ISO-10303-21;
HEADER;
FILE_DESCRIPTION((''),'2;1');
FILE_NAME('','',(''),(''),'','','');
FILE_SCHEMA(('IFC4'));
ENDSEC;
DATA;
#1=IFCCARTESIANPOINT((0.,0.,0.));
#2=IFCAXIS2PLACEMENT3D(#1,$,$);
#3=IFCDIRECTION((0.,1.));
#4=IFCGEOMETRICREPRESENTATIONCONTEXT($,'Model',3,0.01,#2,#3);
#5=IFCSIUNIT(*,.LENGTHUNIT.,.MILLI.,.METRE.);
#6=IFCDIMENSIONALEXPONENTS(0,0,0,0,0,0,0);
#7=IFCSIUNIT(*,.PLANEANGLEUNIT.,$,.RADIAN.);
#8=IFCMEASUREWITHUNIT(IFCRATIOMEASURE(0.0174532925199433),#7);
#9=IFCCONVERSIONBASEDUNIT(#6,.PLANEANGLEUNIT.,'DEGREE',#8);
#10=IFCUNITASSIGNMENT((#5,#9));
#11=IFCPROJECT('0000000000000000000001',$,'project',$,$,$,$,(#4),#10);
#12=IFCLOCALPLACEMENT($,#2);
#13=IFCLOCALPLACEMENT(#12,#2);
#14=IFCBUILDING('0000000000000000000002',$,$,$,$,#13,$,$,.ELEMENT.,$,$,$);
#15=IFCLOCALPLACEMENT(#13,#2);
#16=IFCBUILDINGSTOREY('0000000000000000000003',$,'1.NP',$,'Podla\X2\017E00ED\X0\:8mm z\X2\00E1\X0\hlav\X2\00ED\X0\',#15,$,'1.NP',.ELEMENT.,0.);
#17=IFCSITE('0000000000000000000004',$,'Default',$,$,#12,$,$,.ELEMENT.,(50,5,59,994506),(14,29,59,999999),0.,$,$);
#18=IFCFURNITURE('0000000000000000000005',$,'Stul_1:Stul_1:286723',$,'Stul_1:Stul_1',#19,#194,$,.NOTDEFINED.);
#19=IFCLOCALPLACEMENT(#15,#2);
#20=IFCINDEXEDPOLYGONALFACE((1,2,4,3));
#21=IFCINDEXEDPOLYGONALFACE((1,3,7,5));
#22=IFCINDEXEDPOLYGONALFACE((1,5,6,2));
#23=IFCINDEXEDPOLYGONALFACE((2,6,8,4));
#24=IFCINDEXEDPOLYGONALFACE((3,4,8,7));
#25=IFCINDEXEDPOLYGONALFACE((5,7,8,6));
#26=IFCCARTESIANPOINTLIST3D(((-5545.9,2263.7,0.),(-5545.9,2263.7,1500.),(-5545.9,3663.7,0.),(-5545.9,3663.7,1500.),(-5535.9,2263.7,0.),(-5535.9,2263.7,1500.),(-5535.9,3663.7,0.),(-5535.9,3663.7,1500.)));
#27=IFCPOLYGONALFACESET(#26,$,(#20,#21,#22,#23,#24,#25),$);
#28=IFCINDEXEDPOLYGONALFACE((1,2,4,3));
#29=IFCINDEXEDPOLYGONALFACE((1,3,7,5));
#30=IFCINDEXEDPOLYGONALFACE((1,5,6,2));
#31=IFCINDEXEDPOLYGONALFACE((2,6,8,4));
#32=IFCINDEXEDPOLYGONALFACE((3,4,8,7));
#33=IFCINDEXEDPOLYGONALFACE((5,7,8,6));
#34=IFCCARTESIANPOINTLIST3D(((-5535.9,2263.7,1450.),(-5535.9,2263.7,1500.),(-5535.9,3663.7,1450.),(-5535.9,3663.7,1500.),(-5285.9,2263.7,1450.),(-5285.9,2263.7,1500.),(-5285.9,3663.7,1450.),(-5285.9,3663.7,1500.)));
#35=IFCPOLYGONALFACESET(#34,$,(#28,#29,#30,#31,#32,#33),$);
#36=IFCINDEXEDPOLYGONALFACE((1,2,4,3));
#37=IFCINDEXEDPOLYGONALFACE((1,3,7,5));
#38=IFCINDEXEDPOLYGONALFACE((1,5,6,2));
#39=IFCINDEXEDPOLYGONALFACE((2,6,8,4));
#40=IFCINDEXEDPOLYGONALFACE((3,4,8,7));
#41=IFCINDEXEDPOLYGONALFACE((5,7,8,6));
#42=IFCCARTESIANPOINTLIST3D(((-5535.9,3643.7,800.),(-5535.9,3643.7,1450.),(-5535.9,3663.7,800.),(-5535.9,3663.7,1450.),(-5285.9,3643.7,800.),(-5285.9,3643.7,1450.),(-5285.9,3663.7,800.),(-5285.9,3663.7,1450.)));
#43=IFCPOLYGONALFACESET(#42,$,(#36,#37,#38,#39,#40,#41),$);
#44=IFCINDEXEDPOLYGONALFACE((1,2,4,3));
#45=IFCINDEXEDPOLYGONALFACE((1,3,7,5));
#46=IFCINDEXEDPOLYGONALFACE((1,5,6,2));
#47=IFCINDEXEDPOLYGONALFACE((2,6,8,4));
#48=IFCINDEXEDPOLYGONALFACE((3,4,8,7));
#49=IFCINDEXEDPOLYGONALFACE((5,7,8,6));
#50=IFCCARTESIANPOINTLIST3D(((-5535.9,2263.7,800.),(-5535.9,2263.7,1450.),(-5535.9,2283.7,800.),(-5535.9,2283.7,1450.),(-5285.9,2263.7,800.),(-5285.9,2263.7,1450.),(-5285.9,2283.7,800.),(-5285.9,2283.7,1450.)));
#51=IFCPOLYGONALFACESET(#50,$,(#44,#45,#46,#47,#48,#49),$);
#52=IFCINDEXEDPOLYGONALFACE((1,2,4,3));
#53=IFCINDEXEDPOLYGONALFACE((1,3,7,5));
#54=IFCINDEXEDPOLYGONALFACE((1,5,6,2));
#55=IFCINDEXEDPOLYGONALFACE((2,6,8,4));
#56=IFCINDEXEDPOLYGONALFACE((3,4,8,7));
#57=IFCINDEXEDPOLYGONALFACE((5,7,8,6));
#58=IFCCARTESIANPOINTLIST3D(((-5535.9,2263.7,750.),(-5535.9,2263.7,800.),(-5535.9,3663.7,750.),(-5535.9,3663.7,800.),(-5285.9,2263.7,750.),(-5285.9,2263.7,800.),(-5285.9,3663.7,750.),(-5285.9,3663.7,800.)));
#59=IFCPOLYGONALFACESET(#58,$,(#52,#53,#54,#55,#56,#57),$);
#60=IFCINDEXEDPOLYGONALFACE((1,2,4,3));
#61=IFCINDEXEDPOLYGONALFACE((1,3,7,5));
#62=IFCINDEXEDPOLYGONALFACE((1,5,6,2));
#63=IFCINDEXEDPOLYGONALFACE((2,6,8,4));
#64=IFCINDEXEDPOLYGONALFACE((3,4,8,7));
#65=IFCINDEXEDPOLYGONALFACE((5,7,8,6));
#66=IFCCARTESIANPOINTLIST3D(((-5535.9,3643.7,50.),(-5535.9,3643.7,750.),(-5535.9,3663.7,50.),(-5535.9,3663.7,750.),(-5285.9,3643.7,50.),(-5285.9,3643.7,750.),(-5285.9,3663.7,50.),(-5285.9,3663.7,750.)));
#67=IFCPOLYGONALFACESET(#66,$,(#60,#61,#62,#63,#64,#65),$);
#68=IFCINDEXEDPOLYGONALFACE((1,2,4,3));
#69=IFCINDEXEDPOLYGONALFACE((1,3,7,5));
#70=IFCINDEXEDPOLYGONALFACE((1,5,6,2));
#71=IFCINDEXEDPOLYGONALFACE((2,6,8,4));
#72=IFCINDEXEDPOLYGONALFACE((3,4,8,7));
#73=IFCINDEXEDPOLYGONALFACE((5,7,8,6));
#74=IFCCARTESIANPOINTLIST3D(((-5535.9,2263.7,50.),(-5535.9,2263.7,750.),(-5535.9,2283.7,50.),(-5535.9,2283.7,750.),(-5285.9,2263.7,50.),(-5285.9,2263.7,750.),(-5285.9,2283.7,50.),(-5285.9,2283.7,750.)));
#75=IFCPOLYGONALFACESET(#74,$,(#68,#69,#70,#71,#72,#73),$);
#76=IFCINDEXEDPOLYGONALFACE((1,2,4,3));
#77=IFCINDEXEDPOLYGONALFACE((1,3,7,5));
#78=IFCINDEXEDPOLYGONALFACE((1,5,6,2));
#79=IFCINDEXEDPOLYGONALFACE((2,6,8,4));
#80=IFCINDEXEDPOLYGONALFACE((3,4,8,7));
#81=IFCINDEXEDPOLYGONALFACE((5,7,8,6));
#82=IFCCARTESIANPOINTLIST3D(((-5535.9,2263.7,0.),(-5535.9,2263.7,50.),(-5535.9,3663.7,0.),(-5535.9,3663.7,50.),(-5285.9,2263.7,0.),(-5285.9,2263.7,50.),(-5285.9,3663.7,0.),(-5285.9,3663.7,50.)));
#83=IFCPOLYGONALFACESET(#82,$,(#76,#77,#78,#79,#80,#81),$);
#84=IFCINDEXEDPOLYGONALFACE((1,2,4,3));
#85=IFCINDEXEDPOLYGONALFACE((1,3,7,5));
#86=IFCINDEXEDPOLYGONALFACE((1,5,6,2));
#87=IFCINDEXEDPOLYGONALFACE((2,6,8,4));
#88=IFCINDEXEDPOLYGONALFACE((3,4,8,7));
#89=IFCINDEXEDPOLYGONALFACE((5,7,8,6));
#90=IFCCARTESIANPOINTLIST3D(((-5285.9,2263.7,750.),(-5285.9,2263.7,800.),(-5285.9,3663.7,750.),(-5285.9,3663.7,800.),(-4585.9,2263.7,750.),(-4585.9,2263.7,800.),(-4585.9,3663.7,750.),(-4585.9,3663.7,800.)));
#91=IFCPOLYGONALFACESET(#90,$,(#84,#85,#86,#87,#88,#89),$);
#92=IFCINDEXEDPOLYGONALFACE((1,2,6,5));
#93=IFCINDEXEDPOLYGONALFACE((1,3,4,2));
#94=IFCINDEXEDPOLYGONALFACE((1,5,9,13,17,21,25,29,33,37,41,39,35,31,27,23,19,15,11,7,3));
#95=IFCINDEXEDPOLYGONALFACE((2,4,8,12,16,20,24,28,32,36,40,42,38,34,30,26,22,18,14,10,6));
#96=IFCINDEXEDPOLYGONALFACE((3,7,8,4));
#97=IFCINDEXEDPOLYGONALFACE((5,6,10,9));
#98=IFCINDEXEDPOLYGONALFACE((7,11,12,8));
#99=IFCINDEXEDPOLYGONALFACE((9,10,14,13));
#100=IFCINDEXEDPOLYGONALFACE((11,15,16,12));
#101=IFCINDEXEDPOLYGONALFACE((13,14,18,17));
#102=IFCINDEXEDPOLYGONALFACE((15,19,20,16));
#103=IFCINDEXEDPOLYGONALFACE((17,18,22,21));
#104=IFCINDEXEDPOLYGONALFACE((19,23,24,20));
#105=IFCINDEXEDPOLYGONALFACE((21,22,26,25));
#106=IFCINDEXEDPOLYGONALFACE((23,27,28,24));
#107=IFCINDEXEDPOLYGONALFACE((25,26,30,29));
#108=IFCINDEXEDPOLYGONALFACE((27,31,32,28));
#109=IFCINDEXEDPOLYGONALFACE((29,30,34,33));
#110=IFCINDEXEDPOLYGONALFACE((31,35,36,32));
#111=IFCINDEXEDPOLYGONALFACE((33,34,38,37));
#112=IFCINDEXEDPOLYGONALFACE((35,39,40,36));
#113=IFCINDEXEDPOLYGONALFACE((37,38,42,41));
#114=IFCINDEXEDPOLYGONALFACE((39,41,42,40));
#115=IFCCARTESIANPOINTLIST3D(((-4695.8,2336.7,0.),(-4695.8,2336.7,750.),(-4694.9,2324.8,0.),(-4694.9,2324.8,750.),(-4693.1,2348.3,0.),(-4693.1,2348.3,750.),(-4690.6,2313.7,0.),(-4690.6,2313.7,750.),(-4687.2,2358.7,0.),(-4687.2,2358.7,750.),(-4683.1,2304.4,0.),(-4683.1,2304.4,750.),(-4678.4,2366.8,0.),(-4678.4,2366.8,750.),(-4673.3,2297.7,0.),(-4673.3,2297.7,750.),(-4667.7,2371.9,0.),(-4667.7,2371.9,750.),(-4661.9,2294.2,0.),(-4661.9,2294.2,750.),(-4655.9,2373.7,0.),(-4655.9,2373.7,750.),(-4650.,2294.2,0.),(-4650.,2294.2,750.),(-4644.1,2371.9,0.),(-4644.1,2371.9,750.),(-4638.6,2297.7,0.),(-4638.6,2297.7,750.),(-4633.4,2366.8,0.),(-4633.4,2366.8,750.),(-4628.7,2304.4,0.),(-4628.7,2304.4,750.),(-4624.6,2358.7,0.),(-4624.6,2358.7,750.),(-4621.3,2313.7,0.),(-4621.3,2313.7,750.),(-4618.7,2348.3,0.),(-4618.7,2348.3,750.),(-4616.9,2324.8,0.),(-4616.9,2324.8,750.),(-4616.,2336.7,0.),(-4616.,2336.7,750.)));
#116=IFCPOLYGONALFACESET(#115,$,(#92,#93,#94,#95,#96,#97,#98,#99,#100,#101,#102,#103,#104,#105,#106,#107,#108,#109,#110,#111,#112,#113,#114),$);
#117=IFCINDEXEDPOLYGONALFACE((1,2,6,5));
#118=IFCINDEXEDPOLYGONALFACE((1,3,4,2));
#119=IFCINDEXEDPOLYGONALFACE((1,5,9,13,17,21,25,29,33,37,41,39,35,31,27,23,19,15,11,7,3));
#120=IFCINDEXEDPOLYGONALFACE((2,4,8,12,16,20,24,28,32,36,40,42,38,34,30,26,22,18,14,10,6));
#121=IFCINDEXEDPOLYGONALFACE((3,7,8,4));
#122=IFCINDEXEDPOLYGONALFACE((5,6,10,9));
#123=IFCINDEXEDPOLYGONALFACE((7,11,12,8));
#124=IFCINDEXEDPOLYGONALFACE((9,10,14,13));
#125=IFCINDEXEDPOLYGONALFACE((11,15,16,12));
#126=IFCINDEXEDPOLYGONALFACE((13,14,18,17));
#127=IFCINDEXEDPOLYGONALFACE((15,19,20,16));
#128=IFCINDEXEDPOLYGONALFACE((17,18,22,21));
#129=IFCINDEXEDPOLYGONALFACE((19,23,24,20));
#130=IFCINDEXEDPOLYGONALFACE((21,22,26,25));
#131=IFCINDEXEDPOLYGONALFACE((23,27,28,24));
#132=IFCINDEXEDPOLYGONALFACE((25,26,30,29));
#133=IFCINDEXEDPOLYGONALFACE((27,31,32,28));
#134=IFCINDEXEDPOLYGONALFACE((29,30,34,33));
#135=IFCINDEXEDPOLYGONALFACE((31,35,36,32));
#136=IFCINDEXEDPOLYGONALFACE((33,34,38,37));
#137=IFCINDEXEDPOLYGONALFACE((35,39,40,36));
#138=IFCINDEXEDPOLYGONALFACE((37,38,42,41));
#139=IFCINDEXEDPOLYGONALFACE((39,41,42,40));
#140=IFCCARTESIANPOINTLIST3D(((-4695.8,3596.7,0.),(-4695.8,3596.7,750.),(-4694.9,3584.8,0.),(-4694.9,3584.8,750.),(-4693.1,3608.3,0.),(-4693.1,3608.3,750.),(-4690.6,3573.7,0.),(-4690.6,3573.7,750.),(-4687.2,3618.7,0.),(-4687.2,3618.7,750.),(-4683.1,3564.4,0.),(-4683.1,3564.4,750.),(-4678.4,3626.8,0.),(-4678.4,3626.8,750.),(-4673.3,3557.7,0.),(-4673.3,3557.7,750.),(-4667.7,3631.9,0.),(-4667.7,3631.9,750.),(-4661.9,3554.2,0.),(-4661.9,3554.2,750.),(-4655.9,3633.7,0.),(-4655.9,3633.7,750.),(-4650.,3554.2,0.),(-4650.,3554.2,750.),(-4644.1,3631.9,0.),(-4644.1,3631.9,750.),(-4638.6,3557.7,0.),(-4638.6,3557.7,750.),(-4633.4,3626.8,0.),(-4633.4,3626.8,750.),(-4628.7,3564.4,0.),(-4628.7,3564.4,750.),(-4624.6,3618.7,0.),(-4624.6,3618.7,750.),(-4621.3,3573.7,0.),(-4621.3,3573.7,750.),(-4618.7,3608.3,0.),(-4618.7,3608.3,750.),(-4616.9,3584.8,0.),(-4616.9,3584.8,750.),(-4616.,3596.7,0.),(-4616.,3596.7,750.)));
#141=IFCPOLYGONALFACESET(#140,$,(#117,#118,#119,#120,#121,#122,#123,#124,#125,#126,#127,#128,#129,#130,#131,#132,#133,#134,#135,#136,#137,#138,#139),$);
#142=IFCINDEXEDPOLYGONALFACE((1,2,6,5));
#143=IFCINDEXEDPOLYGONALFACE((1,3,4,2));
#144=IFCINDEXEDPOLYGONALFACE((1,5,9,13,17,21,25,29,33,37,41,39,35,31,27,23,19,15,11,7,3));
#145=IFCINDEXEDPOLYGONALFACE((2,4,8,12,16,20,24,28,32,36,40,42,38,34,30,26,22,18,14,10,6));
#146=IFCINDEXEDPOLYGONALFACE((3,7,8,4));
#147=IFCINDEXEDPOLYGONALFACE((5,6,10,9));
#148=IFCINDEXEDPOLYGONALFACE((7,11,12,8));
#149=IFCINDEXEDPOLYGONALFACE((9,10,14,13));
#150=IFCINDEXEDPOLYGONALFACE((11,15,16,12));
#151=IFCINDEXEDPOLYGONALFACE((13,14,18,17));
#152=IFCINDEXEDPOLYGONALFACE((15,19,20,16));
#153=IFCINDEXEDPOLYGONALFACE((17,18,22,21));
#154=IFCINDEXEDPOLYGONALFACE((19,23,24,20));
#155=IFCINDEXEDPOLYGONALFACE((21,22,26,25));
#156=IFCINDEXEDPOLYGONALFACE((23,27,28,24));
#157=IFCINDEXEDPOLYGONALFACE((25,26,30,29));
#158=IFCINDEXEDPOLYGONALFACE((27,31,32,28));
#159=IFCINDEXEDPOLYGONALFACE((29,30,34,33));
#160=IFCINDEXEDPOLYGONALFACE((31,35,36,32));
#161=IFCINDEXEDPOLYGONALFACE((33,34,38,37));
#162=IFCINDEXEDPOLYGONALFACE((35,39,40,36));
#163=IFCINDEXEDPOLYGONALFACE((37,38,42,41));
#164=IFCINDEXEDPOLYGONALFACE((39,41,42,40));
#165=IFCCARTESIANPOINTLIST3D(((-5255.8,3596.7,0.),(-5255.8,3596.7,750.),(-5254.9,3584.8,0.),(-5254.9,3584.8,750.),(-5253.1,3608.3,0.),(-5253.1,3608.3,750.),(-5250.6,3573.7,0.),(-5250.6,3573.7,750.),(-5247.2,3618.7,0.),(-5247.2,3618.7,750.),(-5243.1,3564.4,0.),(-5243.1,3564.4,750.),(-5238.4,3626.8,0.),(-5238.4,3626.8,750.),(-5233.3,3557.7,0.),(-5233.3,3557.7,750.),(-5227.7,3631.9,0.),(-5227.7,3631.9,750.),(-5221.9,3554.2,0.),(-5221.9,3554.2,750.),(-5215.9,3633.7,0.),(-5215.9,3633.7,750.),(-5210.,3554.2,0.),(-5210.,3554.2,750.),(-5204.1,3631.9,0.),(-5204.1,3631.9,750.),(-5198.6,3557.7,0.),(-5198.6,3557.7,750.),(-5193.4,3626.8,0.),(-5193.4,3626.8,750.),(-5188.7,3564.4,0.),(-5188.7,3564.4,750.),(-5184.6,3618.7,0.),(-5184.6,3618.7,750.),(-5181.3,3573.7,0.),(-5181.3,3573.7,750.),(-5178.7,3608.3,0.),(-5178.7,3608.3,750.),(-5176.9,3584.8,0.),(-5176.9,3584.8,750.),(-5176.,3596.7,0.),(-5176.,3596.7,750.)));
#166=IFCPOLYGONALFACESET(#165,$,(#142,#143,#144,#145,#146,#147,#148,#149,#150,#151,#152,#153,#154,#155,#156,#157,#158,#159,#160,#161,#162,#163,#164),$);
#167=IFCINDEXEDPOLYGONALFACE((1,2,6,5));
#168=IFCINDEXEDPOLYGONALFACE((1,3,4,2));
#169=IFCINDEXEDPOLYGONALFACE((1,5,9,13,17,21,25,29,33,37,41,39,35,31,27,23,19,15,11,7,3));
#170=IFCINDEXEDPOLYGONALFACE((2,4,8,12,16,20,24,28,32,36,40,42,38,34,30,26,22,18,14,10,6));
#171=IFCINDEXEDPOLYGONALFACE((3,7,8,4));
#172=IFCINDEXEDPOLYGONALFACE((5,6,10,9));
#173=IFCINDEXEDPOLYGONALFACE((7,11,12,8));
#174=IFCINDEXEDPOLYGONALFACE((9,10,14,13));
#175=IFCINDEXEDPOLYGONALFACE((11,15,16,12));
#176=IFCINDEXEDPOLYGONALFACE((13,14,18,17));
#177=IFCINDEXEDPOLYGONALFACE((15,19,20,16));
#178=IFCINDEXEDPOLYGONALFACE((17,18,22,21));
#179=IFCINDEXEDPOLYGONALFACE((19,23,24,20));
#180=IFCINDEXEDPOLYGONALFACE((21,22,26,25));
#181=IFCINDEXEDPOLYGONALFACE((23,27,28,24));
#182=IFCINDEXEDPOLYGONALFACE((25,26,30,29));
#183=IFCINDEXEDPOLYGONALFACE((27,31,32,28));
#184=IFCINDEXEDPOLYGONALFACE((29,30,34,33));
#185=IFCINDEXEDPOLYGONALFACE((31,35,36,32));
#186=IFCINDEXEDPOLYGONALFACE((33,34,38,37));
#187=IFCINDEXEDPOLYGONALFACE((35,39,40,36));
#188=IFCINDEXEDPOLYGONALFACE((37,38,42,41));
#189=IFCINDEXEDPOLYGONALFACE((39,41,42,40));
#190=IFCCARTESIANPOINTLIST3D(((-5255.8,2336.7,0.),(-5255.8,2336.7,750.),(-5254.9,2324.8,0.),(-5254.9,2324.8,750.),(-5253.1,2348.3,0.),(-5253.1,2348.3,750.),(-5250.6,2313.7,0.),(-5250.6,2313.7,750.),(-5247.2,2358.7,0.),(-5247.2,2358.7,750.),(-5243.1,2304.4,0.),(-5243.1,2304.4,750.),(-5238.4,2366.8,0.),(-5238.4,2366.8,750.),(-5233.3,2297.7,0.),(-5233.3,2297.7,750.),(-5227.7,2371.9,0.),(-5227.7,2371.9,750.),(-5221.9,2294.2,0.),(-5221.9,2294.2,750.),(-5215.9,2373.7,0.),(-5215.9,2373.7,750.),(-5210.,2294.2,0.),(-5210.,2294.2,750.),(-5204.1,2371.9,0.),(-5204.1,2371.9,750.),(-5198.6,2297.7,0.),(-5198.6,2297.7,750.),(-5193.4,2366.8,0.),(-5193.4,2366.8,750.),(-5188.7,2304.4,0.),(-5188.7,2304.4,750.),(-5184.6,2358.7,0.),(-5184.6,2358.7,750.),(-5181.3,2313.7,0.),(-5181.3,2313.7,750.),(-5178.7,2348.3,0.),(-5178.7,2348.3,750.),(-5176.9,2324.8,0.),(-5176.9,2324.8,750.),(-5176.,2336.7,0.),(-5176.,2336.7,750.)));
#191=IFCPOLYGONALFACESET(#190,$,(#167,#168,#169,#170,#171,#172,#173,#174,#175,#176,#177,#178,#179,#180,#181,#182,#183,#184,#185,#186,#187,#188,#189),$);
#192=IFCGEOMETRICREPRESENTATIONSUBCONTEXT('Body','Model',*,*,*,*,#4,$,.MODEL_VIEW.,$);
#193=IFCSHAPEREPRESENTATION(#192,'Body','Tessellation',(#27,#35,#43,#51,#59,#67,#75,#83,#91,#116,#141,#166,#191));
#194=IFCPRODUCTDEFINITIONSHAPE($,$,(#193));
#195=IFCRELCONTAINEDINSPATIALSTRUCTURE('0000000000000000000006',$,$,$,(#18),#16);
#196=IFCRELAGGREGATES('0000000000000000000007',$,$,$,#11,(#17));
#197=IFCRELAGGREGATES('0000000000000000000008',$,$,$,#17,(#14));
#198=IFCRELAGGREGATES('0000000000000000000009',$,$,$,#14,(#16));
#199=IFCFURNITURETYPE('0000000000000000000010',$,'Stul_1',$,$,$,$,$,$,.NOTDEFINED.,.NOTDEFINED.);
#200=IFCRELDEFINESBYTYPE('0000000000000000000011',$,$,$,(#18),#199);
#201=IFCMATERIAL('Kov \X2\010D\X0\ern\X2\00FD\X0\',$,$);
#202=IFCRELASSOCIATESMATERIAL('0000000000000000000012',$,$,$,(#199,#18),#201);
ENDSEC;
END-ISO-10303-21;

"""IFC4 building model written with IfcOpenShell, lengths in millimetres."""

from ifc_helpers import new_model, entity, si_unit, converted_unit, direction, frame, frame_2d, origin, origin_2d_with_axis, place, context, subcontext, project, spatial, rectangle, circle, extrude, source, transform, mapped, material, type_object, type_shapes, element, save


model = new_model("IFC4")

# Units and contexts
model_context = context("Model", 3, precision=0.01, world=origin(), true_north=direction((0.0, 1.0)))
body_context = subcontext(model_context, "Body", "Model", "MODEL_VIEW")
ifc_project = project(units=[si_unit("LENGTHUNIT", "METRE", prefix="MILLI"), converted_unit("PLANEANGLEUNIT", "DEGREE", entity("IfcRatioMeasure", 0.0174532925199433), si_unit("PLANEANGLEUNIT", "RADIAN"), dimensions=[0, 0, 0, 0, 0, 0, 0])], contexts=[model_context])

# Site, building, storey
site_placement = place(None, origin())
site = spatial("IfcSite", under=ifc_project, at=site_placement, Name="Default", CompositionType="ELEMENT", RefLatitude=(50, 5, 59, 994506), RefLongitude=(14, 29, 59, 999999), RefElevation=0.0)
building_placement = place(site_placement, origin())
building = spatial("IfcBuilding", under=site, at=building_placement, CompositionType="ELEMENT")
storey_placement = place(building_placement, origin())
storey = spatial("IfcBuildingStorey", under=building, at=storey_placement, Name="1.NP", ObjectType="Podlaží:8mm záhlaví", LongName="1.NP", CompositionType="ELEMENT", Elevation=0.0)

# Furniture
ifc_material_1 = material(Name="Kov černý")
furniture_type = type_object("IfcFurnitureType", Name="Stul_1", AssemblyPlace="NOTDEFINED", PredefinedType="NOTDEFINED", material=ifc_material_1)
shared_shape_1 = source(origin(), body_context, "Body", "SweptSolid", [
    extrude(rectangle(XDim=1400.0, YDim=10.0, at=origin_2d_with_axis()), frame((0.0, 605.0, 0.0), z_axis=(0.0, 0.0, 1.0), x_axis=(-1.0, 0.0, 0.0)), (0.0, 0.0, 1.0), 1500.0),
    extrude(rectangle(XDim=1400.0, YDim=250.0, at=frame_2d((0.0, 0.0), x_axis=(1.0, 0.0))), frame((0.0, 475.0, 1450.0), z_axis=(0.0, 0.0, 1.0), x_axis=(-1.0, 0.0, 0.0)), (0.0, 0.0, 1.0), 50.0),
    extrude(rectangle(XDim=20.0, YDim=250.0, at=origin_2d_with_axis()), frame((690.0, 475.0, 800.0), z_axis=(0.0, 0.0, 1.0), x_axis=(-1.0, 0.0, 0.0)), (0.0, 0.0, 1.0), 650.0),
    extrude(rectangle(XDim=20.0, YDim=250.0, at=frame_2d((0.0, 0.0), x_axis=(1.0, 0.0))), frame((-690.0, 475.0, 800.0), z_axis=(0.0, 0.0, 1.0), x_axis=(-1.0, 0.0, 0.0)), (0.0, 0.0, 1.0), 650.0),
    extrude(rectangle(XDim=1400.0, YDim=250.0, at=origin_2d_with_axis()), frame((0.0, 475.0, 750.0), z_axis=(0.0, 0.0, 1.0), x_axis=(-1.0, 0.0, 0.0)), (0.0, 0.0, 1.0), 50.0),
    extrude(rectangle(XDim=20.0, YDim=250.0, at=origin_2d_with_axis()), frame((690.0, 475.0, 50.0), z_axis=(0.0, 0.0, 1.0), x_axis=(-1.0, 0.0, 0.0)), (0.0, 0.0, 1.0), 700.0),
    extrude(rectangle(XDim=20.0, YDim=250.0, at=frame_2d((0.0, 0.0), x_axis=(1.0, 0.0))), frame((-690.0, 475.0, 50.0), z_axis=(0.0, 0.0, 1.0), x_axis=(-1.0, 0.0, 0.0)), (0.0, 0.0, 1.0), 700.0),
    extrude(rectangle(XDim=1400.0, YDim=250.0, at=origin_2d_with_axis()), frame((0.0, 475.0, 0.0), z_axis=(0.0, 0.0, 1.0), x_axis=(-1.0, 0.0, 0.0)), (0.0, 0.0, 1.0), 50.0),
    extrude(rectangle(XDim=1400.0, YDim=700.0, at=origin_2d_with_axis()), frame((0.0, 0.0, 750.0), z_axis=(0.0, 0.0, 1.0), x_axis=(-1.0, 0.0, 0.0)), (0.0, 0.0, 1.0), 50.0),
    extrude(circle(Radius=40.0, at=frame_2d((0.0, 0.0), x_axis=(1.0, 0.0))), frame((-630.0, -280.0, 0.0)), (0.0, 0.0, 1.0), 750.0),
    extrude(circle(Radius=40.0, at=frame_2d((0.0, 0.0), x_axis=(1.0, 0.0))), frame((630.0, -280.0, 0.0)), (0.0, 0.0, 1.0), 750.0),
    extrude(circle(Radius=40.0, at=frame_2d((0.0, 0.0), x_axis=(1.0, 0.0))), frame((630.0, 280.0, 0.0)), (0.0, 0.0, 1.0), 750.0),
    extrude(circle(Radius=40.0, at=frame_2d((0.0, 0.0), x_axis=(1.0, 0.0))), frame((-630.0, 280.0, 0.0)), (0.0, 0.0, 1.0), 750.0),
])
type_shapes(furniture_type, [shared_shape_1])
for number, where, z_axis, x_axis, name in (
    (1, (-4935.9, 2963.7, 0.0), (0.0, 0.0, 1.0), (0.0, 1.0, 0.0), "Stul_1:Stul_1:286723"),
):
    element("IfcFurniture", number, at=place(storey_placement, frame(where, z_axis=z_axis, x_axis=x_axis)), inside=storey, type_object=furniture_type, material=ifc_material_1, Name=name, ObjectType="Stul_1:Stul_1", PredefinedType="NOTDEFINED", context=body_context, shape_type="MappedRepresentation", body=[
        mapped(shared_shape_1, transform((0.0, 0.0, 0.0), scale=1.0)),
    ])

save(model, "model.ifc")
